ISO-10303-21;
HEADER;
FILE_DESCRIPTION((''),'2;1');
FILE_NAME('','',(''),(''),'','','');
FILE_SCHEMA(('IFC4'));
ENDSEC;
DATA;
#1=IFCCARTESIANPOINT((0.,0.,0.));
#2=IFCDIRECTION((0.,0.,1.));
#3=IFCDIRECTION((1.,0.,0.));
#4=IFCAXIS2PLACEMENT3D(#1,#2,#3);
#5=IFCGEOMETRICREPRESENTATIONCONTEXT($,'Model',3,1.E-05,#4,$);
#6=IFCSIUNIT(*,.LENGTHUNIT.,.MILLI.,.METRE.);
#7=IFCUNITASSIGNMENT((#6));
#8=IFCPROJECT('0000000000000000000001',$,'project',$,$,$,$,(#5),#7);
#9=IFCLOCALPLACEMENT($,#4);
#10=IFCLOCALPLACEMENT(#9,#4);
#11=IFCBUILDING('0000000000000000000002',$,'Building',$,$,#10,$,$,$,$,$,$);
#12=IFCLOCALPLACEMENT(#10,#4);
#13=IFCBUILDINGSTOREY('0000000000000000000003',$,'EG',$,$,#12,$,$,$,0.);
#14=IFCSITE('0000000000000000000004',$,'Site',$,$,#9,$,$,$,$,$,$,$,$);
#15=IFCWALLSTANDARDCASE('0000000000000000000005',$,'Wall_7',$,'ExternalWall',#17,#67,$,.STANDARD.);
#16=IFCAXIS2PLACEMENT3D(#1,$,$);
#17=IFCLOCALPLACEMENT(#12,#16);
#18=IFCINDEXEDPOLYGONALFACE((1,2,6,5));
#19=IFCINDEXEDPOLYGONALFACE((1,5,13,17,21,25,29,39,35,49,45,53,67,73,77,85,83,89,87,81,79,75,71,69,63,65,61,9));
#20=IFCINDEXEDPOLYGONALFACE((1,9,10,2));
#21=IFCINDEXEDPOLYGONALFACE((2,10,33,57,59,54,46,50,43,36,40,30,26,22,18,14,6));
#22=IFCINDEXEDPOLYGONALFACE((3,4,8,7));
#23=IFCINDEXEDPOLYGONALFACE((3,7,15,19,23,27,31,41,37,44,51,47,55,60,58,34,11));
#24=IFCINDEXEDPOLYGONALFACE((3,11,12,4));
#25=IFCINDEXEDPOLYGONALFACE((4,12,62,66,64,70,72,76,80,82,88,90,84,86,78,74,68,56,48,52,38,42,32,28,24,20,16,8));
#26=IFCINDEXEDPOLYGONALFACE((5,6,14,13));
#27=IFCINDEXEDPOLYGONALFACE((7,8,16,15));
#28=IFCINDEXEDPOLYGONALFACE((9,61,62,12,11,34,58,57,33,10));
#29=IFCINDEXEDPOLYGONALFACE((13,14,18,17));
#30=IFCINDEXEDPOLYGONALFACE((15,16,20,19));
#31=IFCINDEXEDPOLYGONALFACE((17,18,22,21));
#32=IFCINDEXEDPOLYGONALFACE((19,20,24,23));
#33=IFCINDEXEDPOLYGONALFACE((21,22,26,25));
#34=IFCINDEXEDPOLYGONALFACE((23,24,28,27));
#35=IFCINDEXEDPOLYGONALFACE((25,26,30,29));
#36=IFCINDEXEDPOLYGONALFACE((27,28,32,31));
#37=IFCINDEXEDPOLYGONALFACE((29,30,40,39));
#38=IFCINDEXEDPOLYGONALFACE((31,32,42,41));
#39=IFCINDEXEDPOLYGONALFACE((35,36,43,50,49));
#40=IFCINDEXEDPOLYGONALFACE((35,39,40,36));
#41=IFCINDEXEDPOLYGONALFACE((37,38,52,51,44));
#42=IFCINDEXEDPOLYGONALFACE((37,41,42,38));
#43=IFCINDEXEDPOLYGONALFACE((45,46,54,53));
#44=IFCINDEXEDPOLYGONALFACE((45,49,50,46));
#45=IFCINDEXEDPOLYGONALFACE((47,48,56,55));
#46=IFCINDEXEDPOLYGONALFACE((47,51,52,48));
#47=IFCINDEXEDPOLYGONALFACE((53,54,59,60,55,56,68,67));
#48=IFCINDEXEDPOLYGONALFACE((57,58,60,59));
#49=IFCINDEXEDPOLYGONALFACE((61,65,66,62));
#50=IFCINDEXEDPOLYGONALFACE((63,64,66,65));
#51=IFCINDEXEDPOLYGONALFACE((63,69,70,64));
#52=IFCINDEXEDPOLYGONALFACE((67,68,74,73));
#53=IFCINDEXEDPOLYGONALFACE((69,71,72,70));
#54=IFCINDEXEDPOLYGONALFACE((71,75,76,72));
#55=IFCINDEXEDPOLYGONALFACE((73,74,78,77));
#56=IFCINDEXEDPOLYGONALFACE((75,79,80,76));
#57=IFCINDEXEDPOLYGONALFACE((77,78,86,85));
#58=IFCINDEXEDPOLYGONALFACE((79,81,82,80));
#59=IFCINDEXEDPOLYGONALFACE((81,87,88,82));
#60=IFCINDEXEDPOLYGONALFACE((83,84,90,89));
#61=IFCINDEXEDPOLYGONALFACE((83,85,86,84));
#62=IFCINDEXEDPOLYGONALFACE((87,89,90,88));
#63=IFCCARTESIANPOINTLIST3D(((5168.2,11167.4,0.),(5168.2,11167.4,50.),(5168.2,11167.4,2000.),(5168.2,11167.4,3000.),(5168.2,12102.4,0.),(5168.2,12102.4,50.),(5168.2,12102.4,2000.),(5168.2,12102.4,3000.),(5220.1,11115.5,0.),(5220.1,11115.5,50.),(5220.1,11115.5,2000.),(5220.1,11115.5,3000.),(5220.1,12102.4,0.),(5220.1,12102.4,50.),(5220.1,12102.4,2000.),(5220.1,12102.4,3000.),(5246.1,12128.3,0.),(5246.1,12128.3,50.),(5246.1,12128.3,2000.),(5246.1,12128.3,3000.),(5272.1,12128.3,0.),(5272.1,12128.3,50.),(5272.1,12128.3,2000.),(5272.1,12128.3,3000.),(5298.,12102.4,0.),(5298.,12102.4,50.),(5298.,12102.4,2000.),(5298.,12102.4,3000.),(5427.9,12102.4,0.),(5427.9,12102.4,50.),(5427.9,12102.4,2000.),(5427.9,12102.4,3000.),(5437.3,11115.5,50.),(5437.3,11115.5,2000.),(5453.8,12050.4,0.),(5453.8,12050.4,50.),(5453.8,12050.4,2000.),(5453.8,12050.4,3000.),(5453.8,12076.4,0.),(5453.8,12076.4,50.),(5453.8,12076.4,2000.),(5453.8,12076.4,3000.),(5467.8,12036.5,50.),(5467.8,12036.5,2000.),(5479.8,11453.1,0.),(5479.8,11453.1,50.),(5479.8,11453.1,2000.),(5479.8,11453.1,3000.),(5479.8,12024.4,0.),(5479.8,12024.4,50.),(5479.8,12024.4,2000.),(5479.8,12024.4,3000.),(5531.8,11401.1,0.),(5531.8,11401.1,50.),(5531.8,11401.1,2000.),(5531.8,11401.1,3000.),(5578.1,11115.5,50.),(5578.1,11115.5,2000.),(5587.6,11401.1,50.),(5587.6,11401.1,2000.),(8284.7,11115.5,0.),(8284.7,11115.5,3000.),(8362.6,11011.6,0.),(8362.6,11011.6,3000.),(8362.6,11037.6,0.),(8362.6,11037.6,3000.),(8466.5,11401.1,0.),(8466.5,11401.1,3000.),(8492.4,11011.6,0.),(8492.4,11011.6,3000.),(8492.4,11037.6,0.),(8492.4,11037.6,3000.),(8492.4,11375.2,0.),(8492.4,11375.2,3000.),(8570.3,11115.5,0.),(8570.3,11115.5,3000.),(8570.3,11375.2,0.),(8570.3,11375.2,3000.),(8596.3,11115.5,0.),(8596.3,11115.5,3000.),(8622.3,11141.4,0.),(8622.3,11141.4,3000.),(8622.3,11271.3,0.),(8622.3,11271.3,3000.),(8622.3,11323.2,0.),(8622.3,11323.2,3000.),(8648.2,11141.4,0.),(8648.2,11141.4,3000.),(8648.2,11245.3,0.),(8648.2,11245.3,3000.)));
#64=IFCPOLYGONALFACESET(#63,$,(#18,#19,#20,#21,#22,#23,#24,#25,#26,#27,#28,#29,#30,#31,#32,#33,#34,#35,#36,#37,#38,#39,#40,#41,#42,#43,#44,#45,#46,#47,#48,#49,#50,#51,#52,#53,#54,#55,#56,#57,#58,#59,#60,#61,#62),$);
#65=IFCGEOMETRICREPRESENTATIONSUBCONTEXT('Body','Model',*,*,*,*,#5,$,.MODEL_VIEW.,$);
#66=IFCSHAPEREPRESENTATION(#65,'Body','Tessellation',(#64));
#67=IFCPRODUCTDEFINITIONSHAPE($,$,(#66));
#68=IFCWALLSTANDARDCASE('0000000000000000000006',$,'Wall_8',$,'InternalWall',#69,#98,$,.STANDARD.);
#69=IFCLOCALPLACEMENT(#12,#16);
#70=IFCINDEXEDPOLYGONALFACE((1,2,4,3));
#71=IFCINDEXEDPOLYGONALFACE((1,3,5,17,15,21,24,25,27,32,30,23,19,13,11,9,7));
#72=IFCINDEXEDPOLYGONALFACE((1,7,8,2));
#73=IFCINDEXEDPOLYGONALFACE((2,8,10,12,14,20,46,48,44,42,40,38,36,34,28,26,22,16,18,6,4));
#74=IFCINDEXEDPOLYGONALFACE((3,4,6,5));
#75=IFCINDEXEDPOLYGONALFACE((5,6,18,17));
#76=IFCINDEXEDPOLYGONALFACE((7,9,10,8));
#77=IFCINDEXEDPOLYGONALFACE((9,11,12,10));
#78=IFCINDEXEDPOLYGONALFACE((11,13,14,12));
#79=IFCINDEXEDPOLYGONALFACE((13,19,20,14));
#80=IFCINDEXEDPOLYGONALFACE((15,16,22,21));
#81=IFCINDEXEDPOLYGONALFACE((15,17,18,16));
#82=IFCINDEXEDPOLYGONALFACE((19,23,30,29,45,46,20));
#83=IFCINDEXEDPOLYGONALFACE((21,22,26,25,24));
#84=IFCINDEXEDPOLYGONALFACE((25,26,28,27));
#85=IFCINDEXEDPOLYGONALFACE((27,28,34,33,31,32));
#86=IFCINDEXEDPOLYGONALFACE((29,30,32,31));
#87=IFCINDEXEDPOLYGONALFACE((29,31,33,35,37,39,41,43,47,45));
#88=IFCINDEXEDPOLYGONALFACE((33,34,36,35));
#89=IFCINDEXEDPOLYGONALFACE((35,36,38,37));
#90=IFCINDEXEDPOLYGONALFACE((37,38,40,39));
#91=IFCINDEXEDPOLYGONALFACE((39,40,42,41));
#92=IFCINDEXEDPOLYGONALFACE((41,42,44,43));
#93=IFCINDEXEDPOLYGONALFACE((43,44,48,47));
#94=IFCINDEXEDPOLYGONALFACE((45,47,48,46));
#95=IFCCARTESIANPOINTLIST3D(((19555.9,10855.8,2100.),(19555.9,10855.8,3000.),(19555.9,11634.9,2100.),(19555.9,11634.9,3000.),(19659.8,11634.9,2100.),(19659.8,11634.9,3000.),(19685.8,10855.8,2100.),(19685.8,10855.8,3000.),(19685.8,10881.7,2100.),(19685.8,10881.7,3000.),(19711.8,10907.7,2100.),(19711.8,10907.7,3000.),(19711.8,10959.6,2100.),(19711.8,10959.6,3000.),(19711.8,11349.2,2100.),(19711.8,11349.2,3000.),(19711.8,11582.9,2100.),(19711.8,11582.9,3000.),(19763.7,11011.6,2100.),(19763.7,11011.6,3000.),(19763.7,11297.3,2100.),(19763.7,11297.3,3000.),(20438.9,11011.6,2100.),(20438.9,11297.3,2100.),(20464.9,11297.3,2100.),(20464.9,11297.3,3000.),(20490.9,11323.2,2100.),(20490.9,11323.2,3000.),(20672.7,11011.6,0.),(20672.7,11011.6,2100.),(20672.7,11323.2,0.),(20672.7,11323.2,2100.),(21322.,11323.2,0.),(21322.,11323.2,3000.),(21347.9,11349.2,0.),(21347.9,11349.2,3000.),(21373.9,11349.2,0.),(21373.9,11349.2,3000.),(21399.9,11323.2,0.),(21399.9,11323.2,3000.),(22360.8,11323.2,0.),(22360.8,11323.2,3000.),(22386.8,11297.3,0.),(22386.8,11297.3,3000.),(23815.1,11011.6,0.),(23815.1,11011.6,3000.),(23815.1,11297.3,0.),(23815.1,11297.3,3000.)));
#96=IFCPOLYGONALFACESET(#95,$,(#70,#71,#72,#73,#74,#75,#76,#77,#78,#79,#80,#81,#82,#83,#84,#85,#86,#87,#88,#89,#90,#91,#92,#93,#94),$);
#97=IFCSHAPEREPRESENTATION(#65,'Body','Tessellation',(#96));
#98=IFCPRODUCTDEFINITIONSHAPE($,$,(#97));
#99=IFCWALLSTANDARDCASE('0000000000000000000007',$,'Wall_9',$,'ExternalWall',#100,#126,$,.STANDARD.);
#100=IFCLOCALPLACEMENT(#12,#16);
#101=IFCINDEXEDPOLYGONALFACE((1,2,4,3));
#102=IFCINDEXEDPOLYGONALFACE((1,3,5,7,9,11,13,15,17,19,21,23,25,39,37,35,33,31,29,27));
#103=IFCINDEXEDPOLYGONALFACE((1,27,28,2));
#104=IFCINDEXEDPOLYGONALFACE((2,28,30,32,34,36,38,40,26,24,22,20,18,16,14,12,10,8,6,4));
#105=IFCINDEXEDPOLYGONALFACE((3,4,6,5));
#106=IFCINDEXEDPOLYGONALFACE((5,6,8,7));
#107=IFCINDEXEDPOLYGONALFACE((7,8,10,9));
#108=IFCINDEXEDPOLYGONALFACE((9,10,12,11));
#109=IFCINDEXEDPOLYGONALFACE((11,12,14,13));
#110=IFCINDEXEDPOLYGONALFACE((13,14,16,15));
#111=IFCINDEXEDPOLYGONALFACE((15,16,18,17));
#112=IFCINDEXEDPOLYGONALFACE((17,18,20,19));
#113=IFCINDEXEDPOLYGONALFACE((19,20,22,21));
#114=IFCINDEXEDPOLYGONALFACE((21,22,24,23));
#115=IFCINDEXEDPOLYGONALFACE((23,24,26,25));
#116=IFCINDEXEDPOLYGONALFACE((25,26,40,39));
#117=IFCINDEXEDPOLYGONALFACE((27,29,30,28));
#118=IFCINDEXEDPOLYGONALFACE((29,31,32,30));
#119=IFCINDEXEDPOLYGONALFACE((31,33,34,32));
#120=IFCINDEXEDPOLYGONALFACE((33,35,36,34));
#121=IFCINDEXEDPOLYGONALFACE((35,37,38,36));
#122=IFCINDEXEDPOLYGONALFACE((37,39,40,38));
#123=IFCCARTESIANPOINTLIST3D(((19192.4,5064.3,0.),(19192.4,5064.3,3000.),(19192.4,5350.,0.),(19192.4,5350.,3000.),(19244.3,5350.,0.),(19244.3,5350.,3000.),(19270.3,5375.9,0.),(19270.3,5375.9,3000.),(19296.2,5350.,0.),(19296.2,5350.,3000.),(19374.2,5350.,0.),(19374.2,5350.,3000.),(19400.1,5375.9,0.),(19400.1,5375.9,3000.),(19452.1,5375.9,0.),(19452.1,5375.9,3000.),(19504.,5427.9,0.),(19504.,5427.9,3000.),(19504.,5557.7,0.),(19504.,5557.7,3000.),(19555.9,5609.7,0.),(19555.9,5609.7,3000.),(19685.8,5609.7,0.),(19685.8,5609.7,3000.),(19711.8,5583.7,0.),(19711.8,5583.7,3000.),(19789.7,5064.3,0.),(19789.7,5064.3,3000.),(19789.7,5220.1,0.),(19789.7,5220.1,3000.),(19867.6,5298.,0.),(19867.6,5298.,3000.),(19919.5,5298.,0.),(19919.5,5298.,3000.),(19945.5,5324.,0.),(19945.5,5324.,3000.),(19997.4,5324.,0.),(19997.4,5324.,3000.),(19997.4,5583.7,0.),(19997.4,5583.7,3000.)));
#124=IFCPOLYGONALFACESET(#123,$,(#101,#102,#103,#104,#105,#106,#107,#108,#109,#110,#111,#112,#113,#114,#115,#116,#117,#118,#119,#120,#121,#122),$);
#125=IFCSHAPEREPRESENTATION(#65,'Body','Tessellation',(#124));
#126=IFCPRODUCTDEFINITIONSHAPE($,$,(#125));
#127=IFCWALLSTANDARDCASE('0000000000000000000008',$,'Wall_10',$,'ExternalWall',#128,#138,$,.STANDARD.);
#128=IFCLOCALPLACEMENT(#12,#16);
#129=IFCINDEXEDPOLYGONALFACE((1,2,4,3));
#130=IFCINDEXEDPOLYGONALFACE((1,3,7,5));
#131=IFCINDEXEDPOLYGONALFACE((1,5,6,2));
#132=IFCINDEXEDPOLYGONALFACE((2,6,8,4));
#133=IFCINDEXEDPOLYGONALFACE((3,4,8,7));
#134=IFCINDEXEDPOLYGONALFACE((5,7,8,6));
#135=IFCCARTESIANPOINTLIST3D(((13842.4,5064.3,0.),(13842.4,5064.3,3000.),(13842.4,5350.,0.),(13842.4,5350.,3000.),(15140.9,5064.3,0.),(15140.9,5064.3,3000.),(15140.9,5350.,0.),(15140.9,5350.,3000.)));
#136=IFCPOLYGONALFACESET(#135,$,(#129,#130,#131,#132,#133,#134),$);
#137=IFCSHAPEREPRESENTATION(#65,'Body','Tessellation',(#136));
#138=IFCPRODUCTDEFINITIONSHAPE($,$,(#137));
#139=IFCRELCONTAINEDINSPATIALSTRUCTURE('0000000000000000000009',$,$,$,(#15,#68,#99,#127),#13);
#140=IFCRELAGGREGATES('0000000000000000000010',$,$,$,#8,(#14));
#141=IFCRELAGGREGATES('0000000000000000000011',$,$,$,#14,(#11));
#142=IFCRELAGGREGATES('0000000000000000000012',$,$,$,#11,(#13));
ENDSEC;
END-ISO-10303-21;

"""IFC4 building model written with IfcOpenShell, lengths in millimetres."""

from ifc_helpers import new_model, si_unit, frame, origin_with_axes, place, context, subcontext, project, spatial, polyline, rectangle, outline, extrude, element, save


model = new_model("IFC4")

# Units and contexts
model_context = context("Model", 3, precision=1e-05, world=origin_with_axes())
body_context = subcontext(model_context, "Body", "Model", "MODEL_VIEW")
ifc_project = project(units=[si_unit("LENGTHUNIT", "METRE", prefix="MILLI")], contexts=[model_context])

# Site, building, storey
site_placement = place(None, origin_with_axes())
site = spatial("IfcSite", under=ifc_project, at=site_placement, Name="Site")
building_placement = place(site_placement, origin_with_axes())
building = spatial("IfcBuilding", under=site, at=building_placement, Name="Building")
storey_placement = place(building_placement, origin_with_axes())
storey = spatial("IfcBuildingStorey", under=building, at=storey_placement, Name="EG", Elevation=0.0)

# Walls, openings
wall_1_placement = place(storey_placement, origin_with_axes())
wall_1 = element("IfcWallStandardCase", 1, at=wall_1_placement, inside=storey, Name="Wall_7", ObjectType="ExternalWall", PredefinedType="STANDARD", context=body_context, shape_type="SweptSolid", body=[
    extrude(outline(polyline([(8362.6, 11011.6, 0.0), (8362.6, 11037.6, 0.0), (8284.7, 11115.5, 0.0), (5220.1, 11115.5, 0.0), (5168.2, 11167.4, 0.0), (5168.2, 12102.4, 0.0), (5220.1, 12102.4, 0.0), (5246.1, 12128.3, 0.0), (5272.1, 12128.3, 0.0), (5298.0, 12102.4, 0.0), (5427.9, 12102.4, 0.0), (5453.8, 12076.4, 0.0), (5453.8, 12050.4, 0.0), (5479.8, 12024.4, 0.0), (5479.8, 11453.1, 0.0), (5531.8, 11401.1, 0.0), (8466.5, 11401.1, 0.0), (8492.4, 11375.2, 0.0), (8570.3, 11375.2, 0.0), (8622.3, 11323.2, 0.0), (8622.3, 11271.3, 0.0), (8648.2, 11245.3, 0.0), (8648.2, 11141.4, 0.0), (8622.3, 11141.4, 0.0), (8596.3, 11115.5, 0.0), (8570.3, 11115.5, 0.0), (8492.4, 11037.6, 0.0), (8492.4, 11011.6, 0.0), (8362.6, 11011.6, 0.0)])), origin_with_axes(), (0.0, 0.0, 1.0), 3000.0),
])
opening_1_placement = place(wall_1_placement, origin_with_axes())
element("IfcOpeningElement", 2, at=opening_1_placement, inside=storey, cuts=wall_1, context=body_context, shape_type="SweptSolid", body=[
    extrude(rectangle(XDim=600.0, YDim=1014.0), frame((5294.6, 11620.3, 50.0), z_axis=(0.0, 0.0, 1.0), x_axis=(0.999454, -0.03304, 0.0)), (0.0, 0.0, 1.0), 1950.0),
])
opening_2_placement = place(wall_1_placement, origin_with_axes())
element("IfcOpeningElement", 3, at=opening_2_placement, inside=storey, cuts=wall_1, context=body_context, shape_type="SweptSolid", body=[
    extrude(rectangle(XDim=600.0, YDim=1014.0), frame((5154.0, 11624.9, 50.0), z_axis=(0.0, 0.0, 1.0), x_axis=(0.999454, -0.03304, 0.0)), (0.0, 0.0, 1.0), 1950.0),
])
wall_2_placement = place(storey_placement, origin_with_axes())
wall_2 = element("IfcWallStandardCase", 4, at=wall_2_placement, inside=storey, Name="Wall_8", ObjectType="InternalWall", PredefinedType="STANDARD", context=body_context, shape_type="SweptSolid", body=[
    extrude(outline(polyline([(19555.9, 10855.8, 0.0), (19555.9, 11634.9, 0.0), (19659.8, 11634.9, 0.0), (19711.8, 11582.9, 0.0), (19711.8, 11349.2, 0.0), (19763.7, 11297.3, 0.0), (20464.9, 11297.3, 0.0), (20490.9, 11323.2, 0.0), (21322.0, 11323.2, 0.0), (21347.9, 11349.2, 0.0), (21373.9, 11349.2, 0.0), (21399.9, 11323.2, 0.0), (22360.8, 11323.2, 0.0), (22386.8, 11297.3, 0.0), (23815.1, 11297.3, 0.0), (23815.1, 11011.6, 0.0), (19763.7, 11011.6, 0.0), (19711.8, 10959.6, 0.0), (19711.8, 10907.7, 0.0), (19685.8, 10881.7, 0.0), (19685.8, 10855.8, 0.0), (19555.9, 10855.8, 0.0)])), origin_with_axes(), (0.0, 0.0, 1.0), 3000.0),
])
opening_3_placement = place(wall_2_placement, origin_with_axes())
element("IfcOpeningElement", 5, at=opening_3_placement, inside=storey, cuts=wall_2, context=body_context, shape_type="SweptSolid", body=[
    extrude(rectangle(XDim=1116.7, YDim=779.1), frame((20114.3, 11245.3, 0.0), z_axis=(0.0, 0.0, 1.0), x_axis=(1.0, 0.0, 0.0)), (0.0, 0.0, 1.0), 2100.0),
])
opening_4_placement = place(wall_2_placement, origin_with_axes())
element("IfcOpeningElement", 6, at=opening_4_placement, inside=storey, cuts=wall_2, context=body_context, shape_type="SweptSolid", body=[
    extrude(rectangle(XDim=883.0, YDim=779.1), frame((19997.4, 11245.3, 0.0), z_axis=(0.0, 0.0, 1.0), x_axis=(1.0, 0.0, 0.0)), (0.0, 0.0, 1.0), 2100.0),
])
wall_3_placement = place(storey_placement, origin_with_axes())
wall_3 = element("IfcWallStandardCase", 7, at=wall_3_placement, inside=storey, Name="Wall_9", ObjectType="ExternalWall", PredefinedType="STANDARD", context=body_context, shape_type="SweptSolid", body=[
    extrude(outline(polyline([(19192.4, 5064.3, 0.0), (19192.4, 5350.0, 0.0), (19244.3, 5350.0, 0.0), (19270.3, 5375.9, 0.0), (19296.2, 5350.0, 0.0), (19374.2, 5350.0, 0.0), (19400.1, 5375.9, 0.0), (19452.1, 5375.9, 0.0), (19504.0, 5427.9, 0.0), (19504.0, 5557.7, 0.0), (19555.9, 5609.7, 0.0), (19685.8, 5609.7, 0.0), (19711.8, 5583.7, 0.0), (19997.4, 5583.7, 0.0), (19997.4, 5324.0, 0.0), (19945.5, 5324.0, 0.0), (19919.5, 5298.0, 0.0), (19867.6, 5298.0, 0.0), (19789.7, 5220.1, 0.0), (19789.7, 5064.3, 0.0), (19192.4, 5064.3, 0.0)])), origin_with_axes(), (0.0, 0.0, 1.0), 3000.0),
])
opening_5_placement = place(wall_3_placement, origin_with_axes())
element("IfcOpeningElement", 8, at=opening_5_placement, inside=storey, cuts=wall_3, context=body_context, shape_type="SweptSolid", body=[
    extrude(rectangle(XDim=1200.0, YDim=545.4), frame((18530.1, 5193.9, 50.0), z_axis=(0.0, 0.0, 1.0), x_axis=(1.0, 0.0, 0.0)), (0.0, 0.0, 1.0), 1950.0),
])
opening_6_placement = place(wall_3_placement, origin_with_axes())
element("IfcOpeningElement", 9, at=opening_6_placement, inside=storey, cuts=wall_3, context=body_context, shape_type="SweptSolid", body=[
    extrude(rectangle(XDim=1200.0, YDim=545.4), frame((21763.5, 5492.8, 50.0), z_axis=(0.0, 0.0, 1.0), x_axis=(1.0, 0.0, 0.0)), (0.0, 0.0, 1.0), 1950.0),
])

# Wall
wall_4_placement = place(storey_placement, origin_with_axes())
element("IfcWallStandardCase", 10, at=wall_4_placement, inside=storey, Name="Wall_10", ObjectType="ExternalWall", PredefinedType="STANDARD", context=body_context, shape_type="SweptSolid", body=[
    extrude(outline(polyline([(13842.4, 5064.3, 0.0), (13842.4, 5350.0, 0.0), (15140.9, 5350.0, 0.0), (15140.9, 5064.3, 0.0), (13842.4, 5064.3, 0.0)])), origin_with_axes(), (0.0, 0.0, 1.0), 3000.0),
])

save(model, "model.ifc")
